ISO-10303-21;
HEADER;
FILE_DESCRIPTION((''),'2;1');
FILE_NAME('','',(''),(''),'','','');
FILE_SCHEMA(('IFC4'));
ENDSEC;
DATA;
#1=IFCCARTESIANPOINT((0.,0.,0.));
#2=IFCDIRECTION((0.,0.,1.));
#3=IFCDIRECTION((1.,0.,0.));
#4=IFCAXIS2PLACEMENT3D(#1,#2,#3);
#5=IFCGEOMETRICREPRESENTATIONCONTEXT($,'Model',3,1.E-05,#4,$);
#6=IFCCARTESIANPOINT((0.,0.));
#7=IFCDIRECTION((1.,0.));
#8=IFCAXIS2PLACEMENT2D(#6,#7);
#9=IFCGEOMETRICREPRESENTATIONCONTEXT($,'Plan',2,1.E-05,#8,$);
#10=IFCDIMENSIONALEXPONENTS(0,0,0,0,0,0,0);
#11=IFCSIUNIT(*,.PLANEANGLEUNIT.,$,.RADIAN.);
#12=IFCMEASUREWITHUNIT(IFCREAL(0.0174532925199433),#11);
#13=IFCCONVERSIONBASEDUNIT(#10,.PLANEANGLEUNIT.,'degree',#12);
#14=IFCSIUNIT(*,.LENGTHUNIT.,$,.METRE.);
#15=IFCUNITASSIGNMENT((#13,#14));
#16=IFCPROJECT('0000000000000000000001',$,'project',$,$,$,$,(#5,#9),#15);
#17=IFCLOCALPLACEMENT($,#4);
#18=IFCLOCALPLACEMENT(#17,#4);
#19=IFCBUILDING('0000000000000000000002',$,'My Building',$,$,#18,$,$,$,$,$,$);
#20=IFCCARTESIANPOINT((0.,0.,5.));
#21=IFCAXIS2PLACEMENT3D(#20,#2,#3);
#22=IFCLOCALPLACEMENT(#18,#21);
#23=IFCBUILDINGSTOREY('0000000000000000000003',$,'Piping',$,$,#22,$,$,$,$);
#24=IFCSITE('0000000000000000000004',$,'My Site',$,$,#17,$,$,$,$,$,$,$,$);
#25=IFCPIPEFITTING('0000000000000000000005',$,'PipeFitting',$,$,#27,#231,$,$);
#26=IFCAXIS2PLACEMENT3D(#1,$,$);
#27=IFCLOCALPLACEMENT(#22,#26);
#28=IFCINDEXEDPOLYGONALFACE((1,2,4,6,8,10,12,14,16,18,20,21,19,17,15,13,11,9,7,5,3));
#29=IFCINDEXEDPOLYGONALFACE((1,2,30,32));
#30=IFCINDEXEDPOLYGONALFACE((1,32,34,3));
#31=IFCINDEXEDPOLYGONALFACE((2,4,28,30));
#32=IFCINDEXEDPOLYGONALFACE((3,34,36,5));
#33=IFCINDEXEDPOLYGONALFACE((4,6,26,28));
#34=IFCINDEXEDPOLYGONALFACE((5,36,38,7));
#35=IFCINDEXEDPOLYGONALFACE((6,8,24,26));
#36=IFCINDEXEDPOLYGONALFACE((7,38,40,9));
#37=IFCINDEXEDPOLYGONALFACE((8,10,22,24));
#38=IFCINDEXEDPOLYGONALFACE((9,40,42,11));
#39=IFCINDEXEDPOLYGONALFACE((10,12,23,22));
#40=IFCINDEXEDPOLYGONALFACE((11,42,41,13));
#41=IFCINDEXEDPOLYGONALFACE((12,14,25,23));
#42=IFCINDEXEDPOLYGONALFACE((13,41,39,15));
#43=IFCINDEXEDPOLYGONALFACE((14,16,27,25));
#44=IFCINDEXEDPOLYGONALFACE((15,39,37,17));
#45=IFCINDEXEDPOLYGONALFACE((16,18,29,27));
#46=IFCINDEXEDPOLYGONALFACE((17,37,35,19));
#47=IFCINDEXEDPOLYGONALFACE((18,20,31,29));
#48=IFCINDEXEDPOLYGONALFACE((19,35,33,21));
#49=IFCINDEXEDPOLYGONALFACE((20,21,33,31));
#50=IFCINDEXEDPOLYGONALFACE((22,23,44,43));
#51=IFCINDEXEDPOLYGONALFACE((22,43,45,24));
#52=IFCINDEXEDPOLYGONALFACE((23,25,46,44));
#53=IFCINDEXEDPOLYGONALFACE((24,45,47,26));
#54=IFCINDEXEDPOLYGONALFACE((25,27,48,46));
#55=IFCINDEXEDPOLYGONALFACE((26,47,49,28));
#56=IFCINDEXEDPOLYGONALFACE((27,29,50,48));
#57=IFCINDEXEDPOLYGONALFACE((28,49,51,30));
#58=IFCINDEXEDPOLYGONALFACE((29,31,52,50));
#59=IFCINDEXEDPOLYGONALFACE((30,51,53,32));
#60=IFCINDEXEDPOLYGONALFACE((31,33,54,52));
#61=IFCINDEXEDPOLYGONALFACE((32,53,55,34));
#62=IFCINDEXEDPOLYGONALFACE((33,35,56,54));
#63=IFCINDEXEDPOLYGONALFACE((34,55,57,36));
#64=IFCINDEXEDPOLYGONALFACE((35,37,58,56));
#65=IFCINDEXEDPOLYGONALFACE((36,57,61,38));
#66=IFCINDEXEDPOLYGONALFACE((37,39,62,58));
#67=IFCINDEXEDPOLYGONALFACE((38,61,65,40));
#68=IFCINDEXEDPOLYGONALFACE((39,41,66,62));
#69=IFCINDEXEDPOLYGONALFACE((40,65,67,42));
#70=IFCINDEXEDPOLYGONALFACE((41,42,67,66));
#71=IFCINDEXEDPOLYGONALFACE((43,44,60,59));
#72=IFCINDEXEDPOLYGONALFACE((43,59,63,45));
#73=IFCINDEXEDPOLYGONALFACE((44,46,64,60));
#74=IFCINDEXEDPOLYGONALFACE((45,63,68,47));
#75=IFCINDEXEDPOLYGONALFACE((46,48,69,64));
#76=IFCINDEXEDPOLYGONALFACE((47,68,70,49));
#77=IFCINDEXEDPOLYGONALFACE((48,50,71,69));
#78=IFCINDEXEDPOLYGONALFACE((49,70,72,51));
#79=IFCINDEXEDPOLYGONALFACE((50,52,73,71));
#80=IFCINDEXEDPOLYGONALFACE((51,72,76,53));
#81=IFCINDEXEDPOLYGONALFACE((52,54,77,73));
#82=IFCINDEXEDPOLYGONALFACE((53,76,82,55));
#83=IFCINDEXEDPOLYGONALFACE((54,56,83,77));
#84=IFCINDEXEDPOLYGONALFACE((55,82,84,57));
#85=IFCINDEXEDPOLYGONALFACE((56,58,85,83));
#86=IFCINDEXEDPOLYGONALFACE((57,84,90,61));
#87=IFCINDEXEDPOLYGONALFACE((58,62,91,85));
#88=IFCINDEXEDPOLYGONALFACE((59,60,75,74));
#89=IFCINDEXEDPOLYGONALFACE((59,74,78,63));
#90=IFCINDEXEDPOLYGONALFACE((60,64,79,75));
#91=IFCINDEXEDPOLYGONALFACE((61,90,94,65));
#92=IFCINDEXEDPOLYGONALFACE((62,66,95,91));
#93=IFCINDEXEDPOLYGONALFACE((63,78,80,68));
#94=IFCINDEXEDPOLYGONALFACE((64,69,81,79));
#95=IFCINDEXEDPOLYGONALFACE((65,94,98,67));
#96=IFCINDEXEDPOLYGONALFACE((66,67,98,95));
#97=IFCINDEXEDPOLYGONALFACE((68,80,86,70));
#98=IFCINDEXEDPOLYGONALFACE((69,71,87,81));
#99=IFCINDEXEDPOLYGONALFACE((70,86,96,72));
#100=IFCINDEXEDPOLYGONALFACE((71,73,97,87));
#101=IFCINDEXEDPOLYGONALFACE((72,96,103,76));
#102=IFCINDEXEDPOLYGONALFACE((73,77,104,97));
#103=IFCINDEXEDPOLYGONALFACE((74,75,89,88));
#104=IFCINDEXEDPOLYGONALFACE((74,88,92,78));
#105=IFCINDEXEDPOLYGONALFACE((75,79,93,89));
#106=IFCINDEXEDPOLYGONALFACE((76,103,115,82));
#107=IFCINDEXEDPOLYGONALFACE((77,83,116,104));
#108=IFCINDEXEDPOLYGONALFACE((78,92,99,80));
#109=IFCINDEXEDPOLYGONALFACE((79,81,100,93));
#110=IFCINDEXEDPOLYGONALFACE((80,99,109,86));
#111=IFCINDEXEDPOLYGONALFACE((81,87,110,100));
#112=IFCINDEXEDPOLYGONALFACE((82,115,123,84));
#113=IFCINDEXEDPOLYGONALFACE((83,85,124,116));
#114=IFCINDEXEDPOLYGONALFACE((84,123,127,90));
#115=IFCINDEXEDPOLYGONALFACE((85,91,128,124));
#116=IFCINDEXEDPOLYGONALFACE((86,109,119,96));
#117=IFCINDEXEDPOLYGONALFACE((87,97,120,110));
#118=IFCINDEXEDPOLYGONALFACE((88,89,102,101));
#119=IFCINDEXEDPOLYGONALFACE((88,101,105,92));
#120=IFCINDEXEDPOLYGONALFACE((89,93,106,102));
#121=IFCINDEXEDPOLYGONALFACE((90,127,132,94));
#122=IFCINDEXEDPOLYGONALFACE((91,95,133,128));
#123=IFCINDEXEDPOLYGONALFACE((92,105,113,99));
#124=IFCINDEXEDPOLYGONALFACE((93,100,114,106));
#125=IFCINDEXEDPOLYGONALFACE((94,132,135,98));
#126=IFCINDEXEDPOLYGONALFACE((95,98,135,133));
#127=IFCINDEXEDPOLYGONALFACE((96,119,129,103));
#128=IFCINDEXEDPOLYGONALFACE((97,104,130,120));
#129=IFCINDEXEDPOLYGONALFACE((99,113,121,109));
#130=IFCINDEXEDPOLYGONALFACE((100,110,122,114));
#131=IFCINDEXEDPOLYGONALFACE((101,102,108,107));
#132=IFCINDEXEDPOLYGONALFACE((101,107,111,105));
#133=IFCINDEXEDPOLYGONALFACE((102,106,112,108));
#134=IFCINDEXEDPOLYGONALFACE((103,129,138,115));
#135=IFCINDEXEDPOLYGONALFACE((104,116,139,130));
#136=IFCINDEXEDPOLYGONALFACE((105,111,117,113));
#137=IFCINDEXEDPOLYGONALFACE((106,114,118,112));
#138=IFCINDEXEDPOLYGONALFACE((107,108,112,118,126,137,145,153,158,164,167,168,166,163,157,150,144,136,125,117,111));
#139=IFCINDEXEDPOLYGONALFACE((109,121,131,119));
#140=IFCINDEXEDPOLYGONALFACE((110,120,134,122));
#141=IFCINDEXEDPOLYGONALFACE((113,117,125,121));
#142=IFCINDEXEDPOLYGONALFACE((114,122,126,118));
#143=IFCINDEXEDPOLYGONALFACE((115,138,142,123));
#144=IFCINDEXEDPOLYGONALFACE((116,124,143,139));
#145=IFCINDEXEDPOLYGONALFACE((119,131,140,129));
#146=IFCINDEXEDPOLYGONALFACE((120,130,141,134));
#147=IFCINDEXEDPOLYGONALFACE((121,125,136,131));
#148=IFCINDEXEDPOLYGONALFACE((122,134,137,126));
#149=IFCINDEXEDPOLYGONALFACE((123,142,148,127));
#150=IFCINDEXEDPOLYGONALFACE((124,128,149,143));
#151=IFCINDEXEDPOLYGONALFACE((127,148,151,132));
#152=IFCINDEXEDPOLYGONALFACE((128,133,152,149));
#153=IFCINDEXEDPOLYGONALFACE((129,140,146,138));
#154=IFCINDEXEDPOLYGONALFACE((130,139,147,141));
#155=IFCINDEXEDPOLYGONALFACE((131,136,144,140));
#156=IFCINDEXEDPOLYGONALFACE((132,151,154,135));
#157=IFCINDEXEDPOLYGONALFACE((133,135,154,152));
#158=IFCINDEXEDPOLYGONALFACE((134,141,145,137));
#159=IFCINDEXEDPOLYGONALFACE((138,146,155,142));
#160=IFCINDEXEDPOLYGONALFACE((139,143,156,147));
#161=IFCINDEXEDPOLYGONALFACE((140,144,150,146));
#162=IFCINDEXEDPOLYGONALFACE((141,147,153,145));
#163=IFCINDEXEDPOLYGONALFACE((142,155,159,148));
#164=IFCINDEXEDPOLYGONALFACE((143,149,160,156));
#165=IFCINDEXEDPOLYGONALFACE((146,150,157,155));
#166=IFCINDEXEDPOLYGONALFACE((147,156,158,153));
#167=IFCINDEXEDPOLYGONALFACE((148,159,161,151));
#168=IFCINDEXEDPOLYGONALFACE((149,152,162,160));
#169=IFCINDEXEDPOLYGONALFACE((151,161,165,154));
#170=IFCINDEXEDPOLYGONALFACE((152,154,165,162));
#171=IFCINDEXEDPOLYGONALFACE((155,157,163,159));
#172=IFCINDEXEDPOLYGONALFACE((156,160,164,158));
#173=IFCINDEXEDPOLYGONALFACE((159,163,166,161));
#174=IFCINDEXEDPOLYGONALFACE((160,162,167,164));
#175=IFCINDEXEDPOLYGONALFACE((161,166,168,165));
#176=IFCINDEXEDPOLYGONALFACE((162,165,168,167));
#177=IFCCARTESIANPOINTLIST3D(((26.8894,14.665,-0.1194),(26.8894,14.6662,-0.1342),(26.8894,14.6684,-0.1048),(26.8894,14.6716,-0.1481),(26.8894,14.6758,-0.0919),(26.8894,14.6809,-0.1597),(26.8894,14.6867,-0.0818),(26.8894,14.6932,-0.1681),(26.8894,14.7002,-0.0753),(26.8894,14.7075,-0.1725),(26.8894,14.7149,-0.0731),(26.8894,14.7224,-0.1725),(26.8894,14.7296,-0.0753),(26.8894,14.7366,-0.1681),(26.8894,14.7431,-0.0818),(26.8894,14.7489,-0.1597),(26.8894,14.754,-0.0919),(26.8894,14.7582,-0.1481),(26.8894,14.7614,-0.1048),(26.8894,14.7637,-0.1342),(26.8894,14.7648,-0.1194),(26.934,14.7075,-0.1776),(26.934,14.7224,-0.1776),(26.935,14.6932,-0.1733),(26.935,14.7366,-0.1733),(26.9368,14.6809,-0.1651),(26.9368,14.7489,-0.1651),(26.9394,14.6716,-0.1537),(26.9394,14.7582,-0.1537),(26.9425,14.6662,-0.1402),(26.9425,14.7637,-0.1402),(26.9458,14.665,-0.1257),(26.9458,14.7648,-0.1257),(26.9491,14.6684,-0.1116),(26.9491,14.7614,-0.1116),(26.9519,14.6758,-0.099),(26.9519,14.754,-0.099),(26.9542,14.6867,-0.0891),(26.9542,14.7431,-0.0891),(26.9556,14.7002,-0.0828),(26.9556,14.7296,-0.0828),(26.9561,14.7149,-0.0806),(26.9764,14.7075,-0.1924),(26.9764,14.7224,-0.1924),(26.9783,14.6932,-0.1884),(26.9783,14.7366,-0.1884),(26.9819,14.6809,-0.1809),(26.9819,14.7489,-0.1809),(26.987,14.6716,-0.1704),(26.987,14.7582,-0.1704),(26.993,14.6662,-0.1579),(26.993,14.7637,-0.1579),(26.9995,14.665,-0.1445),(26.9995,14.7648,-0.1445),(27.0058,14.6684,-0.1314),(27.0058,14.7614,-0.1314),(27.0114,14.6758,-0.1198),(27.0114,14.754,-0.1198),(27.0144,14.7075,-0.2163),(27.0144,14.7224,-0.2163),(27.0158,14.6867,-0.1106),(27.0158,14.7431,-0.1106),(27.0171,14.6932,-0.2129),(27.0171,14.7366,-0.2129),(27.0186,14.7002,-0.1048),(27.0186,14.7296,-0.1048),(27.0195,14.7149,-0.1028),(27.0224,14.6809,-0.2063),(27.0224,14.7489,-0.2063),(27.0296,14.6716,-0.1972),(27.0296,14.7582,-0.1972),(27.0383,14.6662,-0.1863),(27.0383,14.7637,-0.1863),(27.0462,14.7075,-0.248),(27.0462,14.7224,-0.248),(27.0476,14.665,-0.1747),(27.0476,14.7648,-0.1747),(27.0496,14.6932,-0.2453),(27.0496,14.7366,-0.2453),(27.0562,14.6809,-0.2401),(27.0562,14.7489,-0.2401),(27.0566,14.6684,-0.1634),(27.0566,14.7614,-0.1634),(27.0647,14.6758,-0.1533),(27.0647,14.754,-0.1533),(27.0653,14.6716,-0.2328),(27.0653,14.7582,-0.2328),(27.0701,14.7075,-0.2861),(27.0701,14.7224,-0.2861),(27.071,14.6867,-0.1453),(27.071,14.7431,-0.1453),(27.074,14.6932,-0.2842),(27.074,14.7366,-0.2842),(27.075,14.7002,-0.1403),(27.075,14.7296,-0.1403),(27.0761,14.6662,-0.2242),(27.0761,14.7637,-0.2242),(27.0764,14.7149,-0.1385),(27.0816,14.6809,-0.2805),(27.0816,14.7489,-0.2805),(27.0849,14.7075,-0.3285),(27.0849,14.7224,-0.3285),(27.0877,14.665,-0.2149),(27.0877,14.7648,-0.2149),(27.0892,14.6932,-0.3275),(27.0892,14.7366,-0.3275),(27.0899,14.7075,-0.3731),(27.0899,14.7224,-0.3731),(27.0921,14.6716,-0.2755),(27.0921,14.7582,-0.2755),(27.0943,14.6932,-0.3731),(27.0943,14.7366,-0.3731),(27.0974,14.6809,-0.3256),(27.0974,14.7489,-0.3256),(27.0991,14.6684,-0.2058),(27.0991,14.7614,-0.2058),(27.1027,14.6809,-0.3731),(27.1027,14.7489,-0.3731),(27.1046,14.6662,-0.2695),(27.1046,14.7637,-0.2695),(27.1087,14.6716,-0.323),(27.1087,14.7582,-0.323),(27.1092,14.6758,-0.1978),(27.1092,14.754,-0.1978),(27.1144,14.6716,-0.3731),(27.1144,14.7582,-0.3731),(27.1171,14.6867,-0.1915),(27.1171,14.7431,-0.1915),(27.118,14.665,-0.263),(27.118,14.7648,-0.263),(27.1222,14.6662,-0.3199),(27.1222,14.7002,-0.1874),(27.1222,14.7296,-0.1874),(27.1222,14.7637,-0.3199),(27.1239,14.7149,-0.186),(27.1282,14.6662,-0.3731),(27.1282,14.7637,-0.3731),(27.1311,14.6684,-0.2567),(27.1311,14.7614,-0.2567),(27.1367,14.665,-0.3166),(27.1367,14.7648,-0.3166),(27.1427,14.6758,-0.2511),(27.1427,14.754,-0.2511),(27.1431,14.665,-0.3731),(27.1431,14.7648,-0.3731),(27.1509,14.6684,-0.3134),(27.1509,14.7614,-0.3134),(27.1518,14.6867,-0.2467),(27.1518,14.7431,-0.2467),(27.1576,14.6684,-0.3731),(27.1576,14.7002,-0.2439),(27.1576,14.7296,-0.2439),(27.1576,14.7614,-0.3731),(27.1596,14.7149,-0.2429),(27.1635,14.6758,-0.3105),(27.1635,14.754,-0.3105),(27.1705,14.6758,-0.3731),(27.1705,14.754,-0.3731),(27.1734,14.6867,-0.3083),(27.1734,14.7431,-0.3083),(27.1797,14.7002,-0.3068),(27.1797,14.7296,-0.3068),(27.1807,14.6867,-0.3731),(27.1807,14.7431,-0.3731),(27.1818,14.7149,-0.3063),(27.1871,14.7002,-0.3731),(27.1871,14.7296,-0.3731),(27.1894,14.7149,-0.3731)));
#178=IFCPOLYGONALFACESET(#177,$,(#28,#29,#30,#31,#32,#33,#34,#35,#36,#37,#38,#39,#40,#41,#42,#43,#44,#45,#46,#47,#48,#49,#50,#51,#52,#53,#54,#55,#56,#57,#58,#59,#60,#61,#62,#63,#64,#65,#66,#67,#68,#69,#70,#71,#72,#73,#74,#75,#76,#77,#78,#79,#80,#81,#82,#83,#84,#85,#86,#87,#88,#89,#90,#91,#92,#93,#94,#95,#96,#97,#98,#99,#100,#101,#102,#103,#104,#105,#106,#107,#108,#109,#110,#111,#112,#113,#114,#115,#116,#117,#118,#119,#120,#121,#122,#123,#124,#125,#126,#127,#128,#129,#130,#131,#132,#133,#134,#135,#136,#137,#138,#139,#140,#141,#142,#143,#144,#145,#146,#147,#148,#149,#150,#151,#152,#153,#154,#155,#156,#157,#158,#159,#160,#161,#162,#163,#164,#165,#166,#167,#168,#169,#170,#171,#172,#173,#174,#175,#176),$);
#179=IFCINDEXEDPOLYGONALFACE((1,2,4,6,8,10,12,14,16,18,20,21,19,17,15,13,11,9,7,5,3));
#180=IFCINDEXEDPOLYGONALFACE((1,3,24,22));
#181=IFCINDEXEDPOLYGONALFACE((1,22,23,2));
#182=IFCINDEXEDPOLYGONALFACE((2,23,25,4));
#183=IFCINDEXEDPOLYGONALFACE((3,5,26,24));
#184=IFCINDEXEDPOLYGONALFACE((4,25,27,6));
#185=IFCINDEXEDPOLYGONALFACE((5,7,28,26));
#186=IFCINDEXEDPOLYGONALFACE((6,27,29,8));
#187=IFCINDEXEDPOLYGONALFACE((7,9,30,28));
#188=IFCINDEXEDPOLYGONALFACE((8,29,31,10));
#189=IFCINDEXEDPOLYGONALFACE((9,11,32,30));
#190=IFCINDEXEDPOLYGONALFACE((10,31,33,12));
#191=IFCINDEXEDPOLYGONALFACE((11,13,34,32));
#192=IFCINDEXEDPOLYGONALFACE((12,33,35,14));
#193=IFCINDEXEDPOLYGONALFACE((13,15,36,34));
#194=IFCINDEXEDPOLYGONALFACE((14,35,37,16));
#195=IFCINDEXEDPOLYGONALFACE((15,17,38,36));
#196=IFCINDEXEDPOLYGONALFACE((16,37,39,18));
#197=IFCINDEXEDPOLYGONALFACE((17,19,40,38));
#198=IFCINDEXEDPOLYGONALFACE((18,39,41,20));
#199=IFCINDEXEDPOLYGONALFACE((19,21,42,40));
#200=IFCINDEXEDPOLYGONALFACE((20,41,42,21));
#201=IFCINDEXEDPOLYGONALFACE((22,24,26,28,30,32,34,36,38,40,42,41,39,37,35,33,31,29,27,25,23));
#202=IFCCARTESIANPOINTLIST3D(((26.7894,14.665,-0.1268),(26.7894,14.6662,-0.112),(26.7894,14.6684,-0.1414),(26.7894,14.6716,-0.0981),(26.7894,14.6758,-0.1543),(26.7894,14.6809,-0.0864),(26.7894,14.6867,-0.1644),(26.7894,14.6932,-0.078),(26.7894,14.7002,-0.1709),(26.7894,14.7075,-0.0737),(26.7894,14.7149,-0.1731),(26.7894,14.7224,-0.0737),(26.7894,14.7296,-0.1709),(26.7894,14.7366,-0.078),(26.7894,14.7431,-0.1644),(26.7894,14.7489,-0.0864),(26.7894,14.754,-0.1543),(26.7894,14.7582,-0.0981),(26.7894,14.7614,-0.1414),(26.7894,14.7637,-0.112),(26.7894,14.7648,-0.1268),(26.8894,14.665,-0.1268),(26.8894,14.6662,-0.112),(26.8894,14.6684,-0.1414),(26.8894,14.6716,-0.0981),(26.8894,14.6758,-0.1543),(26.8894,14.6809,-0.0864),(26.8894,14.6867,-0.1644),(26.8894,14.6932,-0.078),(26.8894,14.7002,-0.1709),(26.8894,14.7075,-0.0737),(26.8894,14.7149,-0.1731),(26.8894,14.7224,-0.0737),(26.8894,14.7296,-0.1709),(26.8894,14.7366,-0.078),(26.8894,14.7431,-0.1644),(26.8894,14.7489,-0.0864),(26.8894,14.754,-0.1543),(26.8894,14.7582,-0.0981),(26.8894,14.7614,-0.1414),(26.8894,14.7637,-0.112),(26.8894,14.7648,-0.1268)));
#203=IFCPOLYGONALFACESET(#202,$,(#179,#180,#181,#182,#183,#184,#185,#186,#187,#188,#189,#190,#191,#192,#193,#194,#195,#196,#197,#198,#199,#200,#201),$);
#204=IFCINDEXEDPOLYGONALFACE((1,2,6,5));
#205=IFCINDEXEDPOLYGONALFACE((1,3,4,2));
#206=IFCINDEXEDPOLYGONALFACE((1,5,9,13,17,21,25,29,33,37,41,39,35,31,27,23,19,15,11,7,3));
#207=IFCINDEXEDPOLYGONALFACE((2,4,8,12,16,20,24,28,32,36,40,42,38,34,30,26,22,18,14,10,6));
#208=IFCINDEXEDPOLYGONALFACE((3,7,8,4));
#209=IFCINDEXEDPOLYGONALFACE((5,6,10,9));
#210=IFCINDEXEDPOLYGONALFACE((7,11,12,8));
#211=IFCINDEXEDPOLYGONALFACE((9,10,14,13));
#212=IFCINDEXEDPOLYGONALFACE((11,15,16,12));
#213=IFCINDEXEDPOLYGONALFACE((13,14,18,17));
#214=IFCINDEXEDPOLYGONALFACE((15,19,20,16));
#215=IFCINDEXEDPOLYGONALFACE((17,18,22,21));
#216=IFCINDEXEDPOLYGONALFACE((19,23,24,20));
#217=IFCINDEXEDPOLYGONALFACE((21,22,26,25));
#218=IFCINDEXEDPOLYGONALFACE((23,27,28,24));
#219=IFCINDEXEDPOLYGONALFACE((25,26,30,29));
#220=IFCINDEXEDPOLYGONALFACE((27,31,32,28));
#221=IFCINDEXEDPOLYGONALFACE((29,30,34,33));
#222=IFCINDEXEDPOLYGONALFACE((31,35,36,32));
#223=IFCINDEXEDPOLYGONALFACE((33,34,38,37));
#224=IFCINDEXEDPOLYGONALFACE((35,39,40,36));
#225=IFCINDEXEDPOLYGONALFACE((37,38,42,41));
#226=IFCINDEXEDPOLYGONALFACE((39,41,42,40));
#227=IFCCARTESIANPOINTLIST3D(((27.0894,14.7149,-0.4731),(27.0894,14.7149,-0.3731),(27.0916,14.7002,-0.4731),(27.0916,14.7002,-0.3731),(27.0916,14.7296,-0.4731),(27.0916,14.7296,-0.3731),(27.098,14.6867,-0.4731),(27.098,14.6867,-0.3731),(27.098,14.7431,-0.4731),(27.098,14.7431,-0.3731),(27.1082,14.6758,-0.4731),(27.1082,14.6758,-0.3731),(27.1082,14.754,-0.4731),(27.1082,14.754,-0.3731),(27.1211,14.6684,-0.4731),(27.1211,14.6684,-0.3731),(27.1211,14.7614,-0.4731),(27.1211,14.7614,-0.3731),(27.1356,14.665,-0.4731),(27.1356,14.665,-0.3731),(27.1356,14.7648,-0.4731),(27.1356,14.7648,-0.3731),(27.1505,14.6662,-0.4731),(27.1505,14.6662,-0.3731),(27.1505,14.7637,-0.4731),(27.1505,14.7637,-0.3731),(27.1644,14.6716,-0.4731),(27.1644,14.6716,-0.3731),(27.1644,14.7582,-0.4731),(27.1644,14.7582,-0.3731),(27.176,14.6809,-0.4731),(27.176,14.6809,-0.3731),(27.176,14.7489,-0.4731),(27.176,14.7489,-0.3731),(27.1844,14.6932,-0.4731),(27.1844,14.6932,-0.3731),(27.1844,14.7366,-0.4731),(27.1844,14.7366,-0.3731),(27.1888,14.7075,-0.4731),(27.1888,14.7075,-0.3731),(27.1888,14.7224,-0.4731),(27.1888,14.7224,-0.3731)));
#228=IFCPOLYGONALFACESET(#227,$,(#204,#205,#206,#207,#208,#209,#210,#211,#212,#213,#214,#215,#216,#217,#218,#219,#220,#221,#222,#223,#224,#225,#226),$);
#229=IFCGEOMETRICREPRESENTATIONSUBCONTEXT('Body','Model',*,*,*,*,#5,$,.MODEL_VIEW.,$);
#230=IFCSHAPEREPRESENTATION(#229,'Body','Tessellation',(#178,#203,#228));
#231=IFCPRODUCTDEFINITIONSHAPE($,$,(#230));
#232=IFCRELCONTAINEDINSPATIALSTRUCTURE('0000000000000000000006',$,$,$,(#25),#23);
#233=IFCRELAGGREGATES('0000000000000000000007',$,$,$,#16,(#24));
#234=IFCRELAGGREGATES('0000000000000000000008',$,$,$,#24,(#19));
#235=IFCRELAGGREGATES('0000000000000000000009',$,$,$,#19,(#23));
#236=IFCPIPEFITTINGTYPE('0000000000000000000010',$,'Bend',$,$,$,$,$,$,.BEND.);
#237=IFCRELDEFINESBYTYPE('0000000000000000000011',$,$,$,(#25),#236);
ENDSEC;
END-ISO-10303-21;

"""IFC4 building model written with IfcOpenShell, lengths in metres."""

from ifc_helpers import new_model, entity, si_unit, converted_unit, frame, origin_with_axes, origin_2d_with_axis, place, context, subcontext, project, spatial, circle, extrude, source, transform, mapped, type_object, type_shapes, element, save


model = new_model("IFC4")

# Units and contexts
model_context = context("Model", 3, precision=1e-05, world=origin_with_axes())
plan_context = context("Plan", 2, precision=1e-05, world=origin_2d_with_axis())
body_context = subcontext(model_context, "Body", "Model", "MODEL_VIEW")
ifc_project = project(units=[converted_unit("PLANEANGLEUNIT", "degree", entity("IfcReal", 0.0174532925199433), si_unit("PLANEANGLEUNIT", "RADIAN"), dimensions=[0, 0, 0, 0, 0, 0, 0]), si_unit("LENGTHUNIT", "METRE")], contexts=[model_context, plan_context])

# Site, building, storey
site_placement = place(None, origin_with_axes())
site = spatial("IfcSite", under=ifc_project, at=site_placement, Name="My Site")
building_placement = place(site_placement, origin_with_axes())
building = spatial("IfcBuilding", under=site, at=building_placement, Name="My Building")
storey_placement = place(building_placement, frame((0.0, 0.0, 5.0), z_axis=(0.0, 0.0, 1.0), x_axis=(1.0, 0.0, 0.0)))
storey = spatial("IfcBuildingStorey", under=building, at=storey_placement, Name="Piping")

# Pipe fitting
pipe_fitting_type_1 = type_object("IfcPipeFittingType", Name="Bend", PredefinedType="BEND")
shared_shape = source(origin_with_axes(), body_context, "Body", "SolidModel", [
    entity("IfcSweptDiskSolid", entity("IfcIndexedPolyCurve", entity("IfcCartesianPointList3D", [[0.0, 0.0, -0.1], [0.0732, 0.0, -0.2768], [0.25, 0.0, -0.35]]), [entity("IfcArcIndex", [1, 2, 3])]), 0.05),
    extrude(circle(Radius=0.05), origin_with_axes(), (0.0, 0.0, -1.0), 0.1),
    extrude(circle(Radius=0.05), frame((0.25, 0.0, -0.35), z_axis=(1.0, 0.0, 0.0), x_axis=(0.0, 0.0, 1.0)), (0.0, 0.0, 1.0), 0.1),
])
type_shapes(pipe_fitting_type_1, [shared_shape])
for number, where, z_axis, x_axis, name in (
    (1, (26.7894, 14.7149, -0.1231), (-1.0, -0.000001, 0.0), (0.0, 0.0, -1.0), "PipeFitting"),
):
    element("IfcPipeFitting", number, at=place(storey_placement, frame(where, z_axis=z_axis, x_axis=x_axis)), inside=storey, type_object=pipe_fitting_type_1, Name=name, context=body_context, shape_type="MappedRepresentation", body=[
        mapped(shared_shape, transform((0.0, 0.0, 0.0), x_axis=(1.0, 0.0, 0.0), y_axis=(0.0, 1.0, 0.0), z_axis=(0.0, 0.0, 1.0), scale=1.0)),
    ])

save(model, "model.ifc")
